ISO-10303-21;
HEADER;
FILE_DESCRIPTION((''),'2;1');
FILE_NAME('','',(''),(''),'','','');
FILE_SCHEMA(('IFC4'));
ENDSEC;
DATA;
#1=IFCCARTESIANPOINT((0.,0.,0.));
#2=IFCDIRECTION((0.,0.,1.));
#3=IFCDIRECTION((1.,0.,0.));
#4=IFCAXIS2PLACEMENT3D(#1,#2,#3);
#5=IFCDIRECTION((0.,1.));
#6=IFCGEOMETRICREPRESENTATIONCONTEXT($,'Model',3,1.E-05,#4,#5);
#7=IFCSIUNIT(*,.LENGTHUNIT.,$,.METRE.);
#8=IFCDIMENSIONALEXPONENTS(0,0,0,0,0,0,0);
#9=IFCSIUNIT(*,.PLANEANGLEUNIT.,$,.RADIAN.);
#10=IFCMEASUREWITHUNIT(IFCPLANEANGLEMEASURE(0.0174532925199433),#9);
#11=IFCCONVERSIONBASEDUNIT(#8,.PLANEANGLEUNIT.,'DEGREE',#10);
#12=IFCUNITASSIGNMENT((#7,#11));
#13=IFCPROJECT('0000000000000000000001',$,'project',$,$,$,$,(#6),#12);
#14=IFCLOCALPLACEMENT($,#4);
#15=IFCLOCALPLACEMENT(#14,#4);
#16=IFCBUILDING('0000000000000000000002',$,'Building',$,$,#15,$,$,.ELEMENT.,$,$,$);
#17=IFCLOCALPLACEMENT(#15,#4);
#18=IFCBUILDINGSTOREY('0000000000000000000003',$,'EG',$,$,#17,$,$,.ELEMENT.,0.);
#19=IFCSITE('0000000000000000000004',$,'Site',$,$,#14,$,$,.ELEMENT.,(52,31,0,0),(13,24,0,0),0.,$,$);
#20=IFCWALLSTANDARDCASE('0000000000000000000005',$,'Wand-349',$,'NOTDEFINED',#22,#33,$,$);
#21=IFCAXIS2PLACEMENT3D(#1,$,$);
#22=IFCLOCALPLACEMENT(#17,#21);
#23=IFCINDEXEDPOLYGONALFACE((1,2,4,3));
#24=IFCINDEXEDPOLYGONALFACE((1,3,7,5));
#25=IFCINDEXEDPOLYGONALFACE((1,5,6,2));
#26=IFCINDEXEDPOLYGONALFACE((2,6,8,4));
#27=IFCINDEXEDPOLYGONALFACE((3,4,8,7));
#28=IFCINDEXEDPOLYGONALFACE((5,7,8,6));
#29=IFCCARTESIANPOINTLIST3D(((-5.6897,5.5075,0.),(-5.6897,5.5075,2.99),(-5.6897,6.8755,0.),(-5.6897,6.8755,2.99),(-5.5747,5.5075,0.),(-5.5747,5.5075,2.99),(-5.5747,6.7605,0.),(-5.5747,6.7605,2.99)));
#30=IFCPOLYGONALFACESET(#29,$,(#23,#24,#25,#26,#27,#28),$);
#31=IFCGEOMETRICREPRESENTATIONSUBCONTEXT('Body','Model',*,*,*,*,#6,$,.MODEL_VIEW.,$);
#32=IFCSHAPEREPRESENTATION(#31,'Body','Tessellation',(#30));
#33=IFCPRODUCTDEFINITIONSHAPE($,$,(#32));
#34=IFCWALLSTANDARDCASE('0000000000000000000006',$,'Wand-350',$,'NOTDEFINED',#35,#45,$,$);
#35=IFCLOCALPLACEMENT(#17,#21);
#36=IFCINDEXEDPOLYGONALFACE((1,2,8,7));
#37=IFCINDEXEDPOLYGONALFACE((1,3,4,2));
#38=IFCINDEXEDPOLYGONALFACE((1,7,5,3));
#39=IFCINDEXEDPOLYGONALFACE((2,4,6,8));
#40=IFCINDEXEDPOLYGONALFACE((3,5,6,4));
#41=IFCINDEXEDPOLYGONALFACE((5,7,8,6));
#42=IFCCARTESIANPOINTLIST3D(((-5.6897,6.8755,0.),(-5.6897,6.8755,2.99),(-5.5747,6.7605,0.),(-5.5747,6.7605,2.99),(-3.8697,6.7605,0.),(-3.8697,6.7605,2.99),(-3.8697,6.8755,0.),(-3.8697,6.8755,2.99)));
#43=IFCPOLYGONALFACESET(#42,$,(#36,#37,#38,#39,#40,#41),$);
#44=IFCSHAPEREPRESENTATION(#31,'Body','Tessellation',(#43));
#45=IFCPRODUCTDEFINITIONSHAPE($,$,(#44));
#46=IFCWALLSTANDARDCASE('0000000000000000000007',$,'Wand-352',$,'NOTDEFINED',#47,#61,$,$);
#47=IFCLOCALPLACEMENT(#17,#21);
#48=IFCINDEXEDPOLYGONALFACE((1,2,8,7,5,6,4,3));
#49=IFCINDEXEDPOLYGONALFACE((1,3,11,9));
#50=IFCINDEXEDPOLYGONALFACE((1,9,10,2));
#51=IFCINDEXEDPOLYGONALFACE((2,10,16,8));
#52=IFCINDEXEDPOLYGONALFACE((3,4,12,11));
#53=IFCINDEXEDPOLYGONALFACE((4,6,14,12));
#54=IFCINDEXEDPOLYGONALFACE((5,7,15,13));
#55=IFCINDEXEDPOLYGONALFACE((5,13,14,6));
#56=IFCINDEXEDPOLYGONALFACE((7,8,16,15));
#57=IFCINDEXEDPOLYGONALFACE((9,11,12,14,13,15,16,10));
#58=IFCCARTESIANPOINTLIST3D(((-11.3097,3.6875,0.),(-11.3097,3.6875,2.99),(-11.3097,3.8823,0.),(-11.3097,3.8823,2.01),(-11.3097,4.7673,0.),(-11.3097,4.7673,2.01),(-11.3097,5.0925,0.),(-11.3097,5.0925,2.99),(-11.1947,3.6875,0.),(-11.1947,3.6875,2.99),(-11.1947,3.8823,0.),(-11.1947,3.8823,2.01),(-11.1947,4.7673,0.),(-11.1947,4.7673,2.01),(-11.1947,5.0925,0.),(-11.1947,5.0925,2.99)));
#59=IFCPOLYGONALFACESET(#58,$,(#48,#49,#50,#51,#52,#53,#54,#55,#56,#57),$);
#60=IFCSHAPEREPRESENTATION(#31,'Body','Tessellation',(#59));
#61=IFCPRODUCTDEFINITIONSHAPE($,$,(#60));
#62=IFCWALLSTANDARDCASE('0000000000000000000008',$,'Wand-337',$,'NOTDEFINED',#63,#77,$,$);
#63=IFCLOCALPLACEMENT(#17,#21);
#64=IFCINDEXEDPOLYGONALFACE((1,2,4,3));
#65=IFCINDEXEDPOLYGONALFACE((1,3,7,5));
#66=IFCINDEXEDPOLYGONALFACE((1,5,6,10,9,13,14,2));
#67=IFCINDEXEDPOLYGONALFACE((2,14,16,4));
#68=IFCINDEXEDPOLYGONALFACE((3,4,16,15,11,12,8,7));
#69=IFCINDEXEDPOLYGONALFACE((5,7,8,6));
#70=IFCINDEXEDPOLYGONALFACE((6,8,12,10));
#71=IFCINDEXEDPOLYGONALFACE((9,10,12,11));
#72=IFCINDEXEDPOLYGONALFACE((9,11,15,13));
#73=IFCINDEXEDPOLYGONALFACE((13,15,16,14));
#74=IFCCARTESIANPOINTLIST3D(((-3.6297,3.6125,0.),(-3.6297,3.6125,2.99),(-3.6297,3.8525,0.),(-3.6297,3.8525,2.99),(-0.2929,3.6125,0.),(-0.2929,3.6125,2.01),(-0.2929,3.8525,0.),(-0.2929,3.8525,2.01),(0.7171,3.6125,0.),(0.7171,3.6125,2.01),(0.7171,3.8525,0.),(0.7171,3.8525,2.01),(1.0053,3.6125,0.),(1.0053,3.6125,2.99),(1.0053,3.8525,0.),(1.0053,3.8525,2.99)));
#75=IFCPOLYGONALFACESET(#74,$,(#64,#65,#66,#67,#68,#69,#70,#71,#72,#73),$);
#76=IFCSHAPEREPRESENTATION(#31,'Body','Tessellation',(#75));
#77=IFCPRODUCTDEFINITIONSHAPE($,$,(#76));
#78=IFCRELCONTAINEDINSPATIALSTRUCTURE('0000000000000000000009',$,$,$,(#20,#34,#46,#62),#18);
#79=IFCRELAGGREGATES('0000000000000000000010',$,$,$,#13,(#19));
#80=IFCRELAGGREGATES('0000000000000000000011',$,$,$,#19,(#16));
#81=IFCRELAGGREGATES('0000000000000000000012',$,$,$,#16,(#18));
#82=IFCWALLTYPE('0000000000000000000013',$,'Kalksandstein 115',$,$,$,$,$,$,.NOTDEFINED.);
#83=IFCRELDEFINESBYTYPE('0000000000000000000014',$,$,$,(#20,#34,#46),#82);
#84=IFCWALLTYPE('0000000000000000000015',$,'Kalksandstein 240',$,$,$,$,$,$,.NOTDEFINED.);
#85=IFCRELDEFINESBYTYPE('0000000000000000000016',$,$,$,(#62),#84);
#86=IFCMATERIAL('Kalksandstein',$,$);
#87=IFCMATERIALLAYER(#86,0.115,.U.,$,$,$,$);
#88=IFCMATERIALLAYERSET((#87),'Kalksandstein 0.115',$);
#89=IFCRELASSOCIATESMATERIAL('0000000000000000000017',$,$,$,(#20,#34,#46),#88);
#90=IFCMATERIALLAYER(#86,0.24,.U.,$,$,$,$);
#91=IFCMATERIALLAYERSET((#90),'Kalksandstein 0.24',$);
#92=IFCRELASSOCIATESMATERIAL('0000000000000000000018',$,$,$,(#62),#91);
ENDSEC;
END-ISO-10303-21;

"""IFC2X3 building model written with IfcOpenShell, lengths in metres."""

from ifc_helpers import new_model, entity, si_unit, converted_unit, direction, frame, origin_with_axes, origin_2d_with_axis, place, context, subcontext, project, spatial, polyline, rectangle, outline, extrude, material, layer, layer_set, layer_usage, type_object, element, save


model = new_model("IFC2X3")

# Units and contexts
model_context = context("Model", 3, precision=1e-05, world=origin_with_axes(), true_north=direction((0.0, 1.0)))
body_context = subcontext(model_context, "Body", "Model", "MODEL_VIEW")
ifc_project = project(units=[si_unit("LENGTHUNIT", "METRE"), converted_unit("PLANEANGLEUNIT", "DEGREE", entity("IfcPlaneAngleMeasure", 0.0174532925199433), si_unit("PLANEANGLEUNIT", "RADIAN"), dimensions=[0, 0, 0, 0, 0, 0, 0])], contexts=[model_context])

# Site, building, storey
site_placement = place(None, origin_with_axes())
site = spatial("IfcSite", under=ifc_project, at=site_placement, Name="Site", CompositionType="ELEMENT", RefLatitude=(52, 31, 0, 0), RefLongitude=(13, 24, 0, 0), RefElevation=0.0)
building_placement = place(site_placement, origin_with_axes())
building = spatial("IfcBuilding", under=site, at=building_placement, Name="Building", CompositionType="ELEMENT")
storey_placement = place(building_placement, origin_with_axes())
storey = spatial("IfcBuildingStorey", under=building, at=storey_placement, Name="EG", CompositionType="ELEMENT", Elevation=0.0)

# Shared definitions
ifc_material_1 = material(Name="Kalksandstein")

# Shared definitions
ifc_layer_1 = layer(ifc_material_1, 0.115, ventilated="UNKNOWN")
ifc_layer_set_1 = layer_set([ifc_layer_1], Name="Kalksandstein 0.115")
wall_type_1 = type_object("IfcWallType", Name="Kalksandstein 115", PredefinedType="NOTDEFINED")

# Walls
ifc_layer_usage_1 = layer_usage(ifc_layer_set_1, "AXIS2", "NEGATIVE", 0.115)
wall_1_placement = place(storey_placement, frame((-5.5747, 5.5075, 0.0), z_axis=(0.0, 0.0, 1.0), x_axis=(0.0, 1.0, 0.0)))
element("IfcWallStandardCase", 1, at=wall_1_placement, inside=storey, type_object=wall_type_1, material=ifc_layer_usage_1, Name="Wand-349", ObjectType="NOTDEFINED", context=body_context, shape_type="SweptSolid", body=[
    extrude(outline(polyline([(0.0, 0.0), (1.253, 0.0), (1.368, 0.115), (0.0, 0.115), (0.0, 0.0)])), origin_with_axes(), (0.0, 0.0, 1.0), 2.99),
])
ifc_layer_usage_2 = layer_usage(ifc_layer_set_1, "AXIS2", "NEGATIVE", 0.115)
wall_2_placement = place(storey_placement, frame((-5.5747, 6.7605, 0.0), z_axis=(0.0, 0.0, 1.0), x_axis=(1.0, 0.0, 0.0)))
element("IfcWallStandardCase", 2, at=wall_2_placement, inside=storey, type_object=wall_type_1, material=ifc_layer_usage_2, Name="Wand-350", ObjectType="NOTDEFINED", context=body_context, shape_type="SweptSolid", body=[
    extrude(outline(polyline([(0.0, 0.0), (1.705, 0.0), (1.705, 0.115), (-0.115, 0.115), (0.0, 0.0)])), origin_with_axes(), (0.0, 0.0, 1.0), 2.99),
])

# Wall, opening
ifc_layer_usage_3 = layer_usage(ifc_layer_set_1, "AXIS2", "NEGATIVE", 0.115)
wall_3_placement = place(storey_placement, frame((-11.3097, 5.0925, 0.0), z_axis=(0.0, 0.0, 1.0), x_axis=(0.0, -1.0, 0.0)))
wall_3 = element("IfcWallStandardCase", 3, at=wall_3_placement, inside=storey, type_object=wall_type_1, material=ifc_layer_usage_3, Name="Wand-352", ObjectType="NOTDEFINED", context=body_context, shape_type="SweptSolid", body=[
    extrude(outline(polyline([(0.0, 0.0), (1.405, 0.0), (1.405, 0.115), (0.0, 0.115), (0.0, 0.0)])), origin_with_axes(), (0.0, 0.0, 1.0), 2.99),
])
opening_1_placement = place(wall_3_placement, frame((0.7677, 0.0, 0.0), z_axis=(0.0, 0.0, 1.0), x_axis=(1.0, 0.0, 0.0)))
element("IfcOpeningElement", 4, at=opening_1_placement, cuts=wall_3, context=body_context, shape_type="SweptSolid", body=[
    extrude(rectangle(XDim=0.885, YDim=2.01, at=origin_2d_with_axis()), frame((0.0, -0.115, 1.005), z_axis=(0.0, 1.0, 0.0), x_axis=(1.0, 0.0, 0.0)), (0.0, 0.0, 1.0), 0.345),
])

# Wall, opening
ifc_layer_2 = layer(ifc_material_1, 0.24, ventilated="UNKNOWN")
ifc_layer_set_2 = layer_set([ifc_layer_2], Name="Kalksandstein 0.24")
wall_type_2 = type_object("IfcWallType", Name="Kalksandstein 240", PredefinedType="NOTDEFINED")
ifc_layer_usage_4 = layer_usage(ifc_layer_set_2, "AXIS2", "NEGATIVE", 0.24)
wall_4_placement = place(storey_placement, frame((-3.6297, 3.6125, 0.0), z_axis=(0.0, 0.0, 1.0), x_axis=(1.0, 0.0, 0.0)))
wall_4 = element("IfcWallStandardCase", 5, at=wall_4_placement, inside=storey, type_object=wall_type_2, material=ifc_layer_usage_4, Name="Wand-337", ObjectType="NOTDEFINED", context=body_context, shape_type="SweptSolid", body=[
    extrude(outline(polyline([(0.0, 0.0), (4.635, 0.0), (4.635, 0.24), (0.0, 0.24), (0.0, 0.0)])), origin_with_axes(), (0.0, 0.0, 1.0), 2.99),
])
opening_2_placement = place(wall_4_placement, frame((3.8418, 0.0, 0.0), z_axis=(0.0, 0.0, 1.0), x_axis=(1.0, 0.0, 0.0)))
element("IfcOpeningElement", 6, at=opening_2_placement, cuts=wall_4, context=body_context, shape_type="SweptSolid", body=[
    extrude(rectangle(XDim=1.01, YDim=2.01, at=origin_2d_with_axis()), frame((0.0, 0.24, 1.005), z_axis=(0.0, 1.0, 0.0), x_axis=(1.0, 0.0, 0.0)), (0.0, 0.0, -1.0), 0.72),
])

save(model, "model.ifc")
